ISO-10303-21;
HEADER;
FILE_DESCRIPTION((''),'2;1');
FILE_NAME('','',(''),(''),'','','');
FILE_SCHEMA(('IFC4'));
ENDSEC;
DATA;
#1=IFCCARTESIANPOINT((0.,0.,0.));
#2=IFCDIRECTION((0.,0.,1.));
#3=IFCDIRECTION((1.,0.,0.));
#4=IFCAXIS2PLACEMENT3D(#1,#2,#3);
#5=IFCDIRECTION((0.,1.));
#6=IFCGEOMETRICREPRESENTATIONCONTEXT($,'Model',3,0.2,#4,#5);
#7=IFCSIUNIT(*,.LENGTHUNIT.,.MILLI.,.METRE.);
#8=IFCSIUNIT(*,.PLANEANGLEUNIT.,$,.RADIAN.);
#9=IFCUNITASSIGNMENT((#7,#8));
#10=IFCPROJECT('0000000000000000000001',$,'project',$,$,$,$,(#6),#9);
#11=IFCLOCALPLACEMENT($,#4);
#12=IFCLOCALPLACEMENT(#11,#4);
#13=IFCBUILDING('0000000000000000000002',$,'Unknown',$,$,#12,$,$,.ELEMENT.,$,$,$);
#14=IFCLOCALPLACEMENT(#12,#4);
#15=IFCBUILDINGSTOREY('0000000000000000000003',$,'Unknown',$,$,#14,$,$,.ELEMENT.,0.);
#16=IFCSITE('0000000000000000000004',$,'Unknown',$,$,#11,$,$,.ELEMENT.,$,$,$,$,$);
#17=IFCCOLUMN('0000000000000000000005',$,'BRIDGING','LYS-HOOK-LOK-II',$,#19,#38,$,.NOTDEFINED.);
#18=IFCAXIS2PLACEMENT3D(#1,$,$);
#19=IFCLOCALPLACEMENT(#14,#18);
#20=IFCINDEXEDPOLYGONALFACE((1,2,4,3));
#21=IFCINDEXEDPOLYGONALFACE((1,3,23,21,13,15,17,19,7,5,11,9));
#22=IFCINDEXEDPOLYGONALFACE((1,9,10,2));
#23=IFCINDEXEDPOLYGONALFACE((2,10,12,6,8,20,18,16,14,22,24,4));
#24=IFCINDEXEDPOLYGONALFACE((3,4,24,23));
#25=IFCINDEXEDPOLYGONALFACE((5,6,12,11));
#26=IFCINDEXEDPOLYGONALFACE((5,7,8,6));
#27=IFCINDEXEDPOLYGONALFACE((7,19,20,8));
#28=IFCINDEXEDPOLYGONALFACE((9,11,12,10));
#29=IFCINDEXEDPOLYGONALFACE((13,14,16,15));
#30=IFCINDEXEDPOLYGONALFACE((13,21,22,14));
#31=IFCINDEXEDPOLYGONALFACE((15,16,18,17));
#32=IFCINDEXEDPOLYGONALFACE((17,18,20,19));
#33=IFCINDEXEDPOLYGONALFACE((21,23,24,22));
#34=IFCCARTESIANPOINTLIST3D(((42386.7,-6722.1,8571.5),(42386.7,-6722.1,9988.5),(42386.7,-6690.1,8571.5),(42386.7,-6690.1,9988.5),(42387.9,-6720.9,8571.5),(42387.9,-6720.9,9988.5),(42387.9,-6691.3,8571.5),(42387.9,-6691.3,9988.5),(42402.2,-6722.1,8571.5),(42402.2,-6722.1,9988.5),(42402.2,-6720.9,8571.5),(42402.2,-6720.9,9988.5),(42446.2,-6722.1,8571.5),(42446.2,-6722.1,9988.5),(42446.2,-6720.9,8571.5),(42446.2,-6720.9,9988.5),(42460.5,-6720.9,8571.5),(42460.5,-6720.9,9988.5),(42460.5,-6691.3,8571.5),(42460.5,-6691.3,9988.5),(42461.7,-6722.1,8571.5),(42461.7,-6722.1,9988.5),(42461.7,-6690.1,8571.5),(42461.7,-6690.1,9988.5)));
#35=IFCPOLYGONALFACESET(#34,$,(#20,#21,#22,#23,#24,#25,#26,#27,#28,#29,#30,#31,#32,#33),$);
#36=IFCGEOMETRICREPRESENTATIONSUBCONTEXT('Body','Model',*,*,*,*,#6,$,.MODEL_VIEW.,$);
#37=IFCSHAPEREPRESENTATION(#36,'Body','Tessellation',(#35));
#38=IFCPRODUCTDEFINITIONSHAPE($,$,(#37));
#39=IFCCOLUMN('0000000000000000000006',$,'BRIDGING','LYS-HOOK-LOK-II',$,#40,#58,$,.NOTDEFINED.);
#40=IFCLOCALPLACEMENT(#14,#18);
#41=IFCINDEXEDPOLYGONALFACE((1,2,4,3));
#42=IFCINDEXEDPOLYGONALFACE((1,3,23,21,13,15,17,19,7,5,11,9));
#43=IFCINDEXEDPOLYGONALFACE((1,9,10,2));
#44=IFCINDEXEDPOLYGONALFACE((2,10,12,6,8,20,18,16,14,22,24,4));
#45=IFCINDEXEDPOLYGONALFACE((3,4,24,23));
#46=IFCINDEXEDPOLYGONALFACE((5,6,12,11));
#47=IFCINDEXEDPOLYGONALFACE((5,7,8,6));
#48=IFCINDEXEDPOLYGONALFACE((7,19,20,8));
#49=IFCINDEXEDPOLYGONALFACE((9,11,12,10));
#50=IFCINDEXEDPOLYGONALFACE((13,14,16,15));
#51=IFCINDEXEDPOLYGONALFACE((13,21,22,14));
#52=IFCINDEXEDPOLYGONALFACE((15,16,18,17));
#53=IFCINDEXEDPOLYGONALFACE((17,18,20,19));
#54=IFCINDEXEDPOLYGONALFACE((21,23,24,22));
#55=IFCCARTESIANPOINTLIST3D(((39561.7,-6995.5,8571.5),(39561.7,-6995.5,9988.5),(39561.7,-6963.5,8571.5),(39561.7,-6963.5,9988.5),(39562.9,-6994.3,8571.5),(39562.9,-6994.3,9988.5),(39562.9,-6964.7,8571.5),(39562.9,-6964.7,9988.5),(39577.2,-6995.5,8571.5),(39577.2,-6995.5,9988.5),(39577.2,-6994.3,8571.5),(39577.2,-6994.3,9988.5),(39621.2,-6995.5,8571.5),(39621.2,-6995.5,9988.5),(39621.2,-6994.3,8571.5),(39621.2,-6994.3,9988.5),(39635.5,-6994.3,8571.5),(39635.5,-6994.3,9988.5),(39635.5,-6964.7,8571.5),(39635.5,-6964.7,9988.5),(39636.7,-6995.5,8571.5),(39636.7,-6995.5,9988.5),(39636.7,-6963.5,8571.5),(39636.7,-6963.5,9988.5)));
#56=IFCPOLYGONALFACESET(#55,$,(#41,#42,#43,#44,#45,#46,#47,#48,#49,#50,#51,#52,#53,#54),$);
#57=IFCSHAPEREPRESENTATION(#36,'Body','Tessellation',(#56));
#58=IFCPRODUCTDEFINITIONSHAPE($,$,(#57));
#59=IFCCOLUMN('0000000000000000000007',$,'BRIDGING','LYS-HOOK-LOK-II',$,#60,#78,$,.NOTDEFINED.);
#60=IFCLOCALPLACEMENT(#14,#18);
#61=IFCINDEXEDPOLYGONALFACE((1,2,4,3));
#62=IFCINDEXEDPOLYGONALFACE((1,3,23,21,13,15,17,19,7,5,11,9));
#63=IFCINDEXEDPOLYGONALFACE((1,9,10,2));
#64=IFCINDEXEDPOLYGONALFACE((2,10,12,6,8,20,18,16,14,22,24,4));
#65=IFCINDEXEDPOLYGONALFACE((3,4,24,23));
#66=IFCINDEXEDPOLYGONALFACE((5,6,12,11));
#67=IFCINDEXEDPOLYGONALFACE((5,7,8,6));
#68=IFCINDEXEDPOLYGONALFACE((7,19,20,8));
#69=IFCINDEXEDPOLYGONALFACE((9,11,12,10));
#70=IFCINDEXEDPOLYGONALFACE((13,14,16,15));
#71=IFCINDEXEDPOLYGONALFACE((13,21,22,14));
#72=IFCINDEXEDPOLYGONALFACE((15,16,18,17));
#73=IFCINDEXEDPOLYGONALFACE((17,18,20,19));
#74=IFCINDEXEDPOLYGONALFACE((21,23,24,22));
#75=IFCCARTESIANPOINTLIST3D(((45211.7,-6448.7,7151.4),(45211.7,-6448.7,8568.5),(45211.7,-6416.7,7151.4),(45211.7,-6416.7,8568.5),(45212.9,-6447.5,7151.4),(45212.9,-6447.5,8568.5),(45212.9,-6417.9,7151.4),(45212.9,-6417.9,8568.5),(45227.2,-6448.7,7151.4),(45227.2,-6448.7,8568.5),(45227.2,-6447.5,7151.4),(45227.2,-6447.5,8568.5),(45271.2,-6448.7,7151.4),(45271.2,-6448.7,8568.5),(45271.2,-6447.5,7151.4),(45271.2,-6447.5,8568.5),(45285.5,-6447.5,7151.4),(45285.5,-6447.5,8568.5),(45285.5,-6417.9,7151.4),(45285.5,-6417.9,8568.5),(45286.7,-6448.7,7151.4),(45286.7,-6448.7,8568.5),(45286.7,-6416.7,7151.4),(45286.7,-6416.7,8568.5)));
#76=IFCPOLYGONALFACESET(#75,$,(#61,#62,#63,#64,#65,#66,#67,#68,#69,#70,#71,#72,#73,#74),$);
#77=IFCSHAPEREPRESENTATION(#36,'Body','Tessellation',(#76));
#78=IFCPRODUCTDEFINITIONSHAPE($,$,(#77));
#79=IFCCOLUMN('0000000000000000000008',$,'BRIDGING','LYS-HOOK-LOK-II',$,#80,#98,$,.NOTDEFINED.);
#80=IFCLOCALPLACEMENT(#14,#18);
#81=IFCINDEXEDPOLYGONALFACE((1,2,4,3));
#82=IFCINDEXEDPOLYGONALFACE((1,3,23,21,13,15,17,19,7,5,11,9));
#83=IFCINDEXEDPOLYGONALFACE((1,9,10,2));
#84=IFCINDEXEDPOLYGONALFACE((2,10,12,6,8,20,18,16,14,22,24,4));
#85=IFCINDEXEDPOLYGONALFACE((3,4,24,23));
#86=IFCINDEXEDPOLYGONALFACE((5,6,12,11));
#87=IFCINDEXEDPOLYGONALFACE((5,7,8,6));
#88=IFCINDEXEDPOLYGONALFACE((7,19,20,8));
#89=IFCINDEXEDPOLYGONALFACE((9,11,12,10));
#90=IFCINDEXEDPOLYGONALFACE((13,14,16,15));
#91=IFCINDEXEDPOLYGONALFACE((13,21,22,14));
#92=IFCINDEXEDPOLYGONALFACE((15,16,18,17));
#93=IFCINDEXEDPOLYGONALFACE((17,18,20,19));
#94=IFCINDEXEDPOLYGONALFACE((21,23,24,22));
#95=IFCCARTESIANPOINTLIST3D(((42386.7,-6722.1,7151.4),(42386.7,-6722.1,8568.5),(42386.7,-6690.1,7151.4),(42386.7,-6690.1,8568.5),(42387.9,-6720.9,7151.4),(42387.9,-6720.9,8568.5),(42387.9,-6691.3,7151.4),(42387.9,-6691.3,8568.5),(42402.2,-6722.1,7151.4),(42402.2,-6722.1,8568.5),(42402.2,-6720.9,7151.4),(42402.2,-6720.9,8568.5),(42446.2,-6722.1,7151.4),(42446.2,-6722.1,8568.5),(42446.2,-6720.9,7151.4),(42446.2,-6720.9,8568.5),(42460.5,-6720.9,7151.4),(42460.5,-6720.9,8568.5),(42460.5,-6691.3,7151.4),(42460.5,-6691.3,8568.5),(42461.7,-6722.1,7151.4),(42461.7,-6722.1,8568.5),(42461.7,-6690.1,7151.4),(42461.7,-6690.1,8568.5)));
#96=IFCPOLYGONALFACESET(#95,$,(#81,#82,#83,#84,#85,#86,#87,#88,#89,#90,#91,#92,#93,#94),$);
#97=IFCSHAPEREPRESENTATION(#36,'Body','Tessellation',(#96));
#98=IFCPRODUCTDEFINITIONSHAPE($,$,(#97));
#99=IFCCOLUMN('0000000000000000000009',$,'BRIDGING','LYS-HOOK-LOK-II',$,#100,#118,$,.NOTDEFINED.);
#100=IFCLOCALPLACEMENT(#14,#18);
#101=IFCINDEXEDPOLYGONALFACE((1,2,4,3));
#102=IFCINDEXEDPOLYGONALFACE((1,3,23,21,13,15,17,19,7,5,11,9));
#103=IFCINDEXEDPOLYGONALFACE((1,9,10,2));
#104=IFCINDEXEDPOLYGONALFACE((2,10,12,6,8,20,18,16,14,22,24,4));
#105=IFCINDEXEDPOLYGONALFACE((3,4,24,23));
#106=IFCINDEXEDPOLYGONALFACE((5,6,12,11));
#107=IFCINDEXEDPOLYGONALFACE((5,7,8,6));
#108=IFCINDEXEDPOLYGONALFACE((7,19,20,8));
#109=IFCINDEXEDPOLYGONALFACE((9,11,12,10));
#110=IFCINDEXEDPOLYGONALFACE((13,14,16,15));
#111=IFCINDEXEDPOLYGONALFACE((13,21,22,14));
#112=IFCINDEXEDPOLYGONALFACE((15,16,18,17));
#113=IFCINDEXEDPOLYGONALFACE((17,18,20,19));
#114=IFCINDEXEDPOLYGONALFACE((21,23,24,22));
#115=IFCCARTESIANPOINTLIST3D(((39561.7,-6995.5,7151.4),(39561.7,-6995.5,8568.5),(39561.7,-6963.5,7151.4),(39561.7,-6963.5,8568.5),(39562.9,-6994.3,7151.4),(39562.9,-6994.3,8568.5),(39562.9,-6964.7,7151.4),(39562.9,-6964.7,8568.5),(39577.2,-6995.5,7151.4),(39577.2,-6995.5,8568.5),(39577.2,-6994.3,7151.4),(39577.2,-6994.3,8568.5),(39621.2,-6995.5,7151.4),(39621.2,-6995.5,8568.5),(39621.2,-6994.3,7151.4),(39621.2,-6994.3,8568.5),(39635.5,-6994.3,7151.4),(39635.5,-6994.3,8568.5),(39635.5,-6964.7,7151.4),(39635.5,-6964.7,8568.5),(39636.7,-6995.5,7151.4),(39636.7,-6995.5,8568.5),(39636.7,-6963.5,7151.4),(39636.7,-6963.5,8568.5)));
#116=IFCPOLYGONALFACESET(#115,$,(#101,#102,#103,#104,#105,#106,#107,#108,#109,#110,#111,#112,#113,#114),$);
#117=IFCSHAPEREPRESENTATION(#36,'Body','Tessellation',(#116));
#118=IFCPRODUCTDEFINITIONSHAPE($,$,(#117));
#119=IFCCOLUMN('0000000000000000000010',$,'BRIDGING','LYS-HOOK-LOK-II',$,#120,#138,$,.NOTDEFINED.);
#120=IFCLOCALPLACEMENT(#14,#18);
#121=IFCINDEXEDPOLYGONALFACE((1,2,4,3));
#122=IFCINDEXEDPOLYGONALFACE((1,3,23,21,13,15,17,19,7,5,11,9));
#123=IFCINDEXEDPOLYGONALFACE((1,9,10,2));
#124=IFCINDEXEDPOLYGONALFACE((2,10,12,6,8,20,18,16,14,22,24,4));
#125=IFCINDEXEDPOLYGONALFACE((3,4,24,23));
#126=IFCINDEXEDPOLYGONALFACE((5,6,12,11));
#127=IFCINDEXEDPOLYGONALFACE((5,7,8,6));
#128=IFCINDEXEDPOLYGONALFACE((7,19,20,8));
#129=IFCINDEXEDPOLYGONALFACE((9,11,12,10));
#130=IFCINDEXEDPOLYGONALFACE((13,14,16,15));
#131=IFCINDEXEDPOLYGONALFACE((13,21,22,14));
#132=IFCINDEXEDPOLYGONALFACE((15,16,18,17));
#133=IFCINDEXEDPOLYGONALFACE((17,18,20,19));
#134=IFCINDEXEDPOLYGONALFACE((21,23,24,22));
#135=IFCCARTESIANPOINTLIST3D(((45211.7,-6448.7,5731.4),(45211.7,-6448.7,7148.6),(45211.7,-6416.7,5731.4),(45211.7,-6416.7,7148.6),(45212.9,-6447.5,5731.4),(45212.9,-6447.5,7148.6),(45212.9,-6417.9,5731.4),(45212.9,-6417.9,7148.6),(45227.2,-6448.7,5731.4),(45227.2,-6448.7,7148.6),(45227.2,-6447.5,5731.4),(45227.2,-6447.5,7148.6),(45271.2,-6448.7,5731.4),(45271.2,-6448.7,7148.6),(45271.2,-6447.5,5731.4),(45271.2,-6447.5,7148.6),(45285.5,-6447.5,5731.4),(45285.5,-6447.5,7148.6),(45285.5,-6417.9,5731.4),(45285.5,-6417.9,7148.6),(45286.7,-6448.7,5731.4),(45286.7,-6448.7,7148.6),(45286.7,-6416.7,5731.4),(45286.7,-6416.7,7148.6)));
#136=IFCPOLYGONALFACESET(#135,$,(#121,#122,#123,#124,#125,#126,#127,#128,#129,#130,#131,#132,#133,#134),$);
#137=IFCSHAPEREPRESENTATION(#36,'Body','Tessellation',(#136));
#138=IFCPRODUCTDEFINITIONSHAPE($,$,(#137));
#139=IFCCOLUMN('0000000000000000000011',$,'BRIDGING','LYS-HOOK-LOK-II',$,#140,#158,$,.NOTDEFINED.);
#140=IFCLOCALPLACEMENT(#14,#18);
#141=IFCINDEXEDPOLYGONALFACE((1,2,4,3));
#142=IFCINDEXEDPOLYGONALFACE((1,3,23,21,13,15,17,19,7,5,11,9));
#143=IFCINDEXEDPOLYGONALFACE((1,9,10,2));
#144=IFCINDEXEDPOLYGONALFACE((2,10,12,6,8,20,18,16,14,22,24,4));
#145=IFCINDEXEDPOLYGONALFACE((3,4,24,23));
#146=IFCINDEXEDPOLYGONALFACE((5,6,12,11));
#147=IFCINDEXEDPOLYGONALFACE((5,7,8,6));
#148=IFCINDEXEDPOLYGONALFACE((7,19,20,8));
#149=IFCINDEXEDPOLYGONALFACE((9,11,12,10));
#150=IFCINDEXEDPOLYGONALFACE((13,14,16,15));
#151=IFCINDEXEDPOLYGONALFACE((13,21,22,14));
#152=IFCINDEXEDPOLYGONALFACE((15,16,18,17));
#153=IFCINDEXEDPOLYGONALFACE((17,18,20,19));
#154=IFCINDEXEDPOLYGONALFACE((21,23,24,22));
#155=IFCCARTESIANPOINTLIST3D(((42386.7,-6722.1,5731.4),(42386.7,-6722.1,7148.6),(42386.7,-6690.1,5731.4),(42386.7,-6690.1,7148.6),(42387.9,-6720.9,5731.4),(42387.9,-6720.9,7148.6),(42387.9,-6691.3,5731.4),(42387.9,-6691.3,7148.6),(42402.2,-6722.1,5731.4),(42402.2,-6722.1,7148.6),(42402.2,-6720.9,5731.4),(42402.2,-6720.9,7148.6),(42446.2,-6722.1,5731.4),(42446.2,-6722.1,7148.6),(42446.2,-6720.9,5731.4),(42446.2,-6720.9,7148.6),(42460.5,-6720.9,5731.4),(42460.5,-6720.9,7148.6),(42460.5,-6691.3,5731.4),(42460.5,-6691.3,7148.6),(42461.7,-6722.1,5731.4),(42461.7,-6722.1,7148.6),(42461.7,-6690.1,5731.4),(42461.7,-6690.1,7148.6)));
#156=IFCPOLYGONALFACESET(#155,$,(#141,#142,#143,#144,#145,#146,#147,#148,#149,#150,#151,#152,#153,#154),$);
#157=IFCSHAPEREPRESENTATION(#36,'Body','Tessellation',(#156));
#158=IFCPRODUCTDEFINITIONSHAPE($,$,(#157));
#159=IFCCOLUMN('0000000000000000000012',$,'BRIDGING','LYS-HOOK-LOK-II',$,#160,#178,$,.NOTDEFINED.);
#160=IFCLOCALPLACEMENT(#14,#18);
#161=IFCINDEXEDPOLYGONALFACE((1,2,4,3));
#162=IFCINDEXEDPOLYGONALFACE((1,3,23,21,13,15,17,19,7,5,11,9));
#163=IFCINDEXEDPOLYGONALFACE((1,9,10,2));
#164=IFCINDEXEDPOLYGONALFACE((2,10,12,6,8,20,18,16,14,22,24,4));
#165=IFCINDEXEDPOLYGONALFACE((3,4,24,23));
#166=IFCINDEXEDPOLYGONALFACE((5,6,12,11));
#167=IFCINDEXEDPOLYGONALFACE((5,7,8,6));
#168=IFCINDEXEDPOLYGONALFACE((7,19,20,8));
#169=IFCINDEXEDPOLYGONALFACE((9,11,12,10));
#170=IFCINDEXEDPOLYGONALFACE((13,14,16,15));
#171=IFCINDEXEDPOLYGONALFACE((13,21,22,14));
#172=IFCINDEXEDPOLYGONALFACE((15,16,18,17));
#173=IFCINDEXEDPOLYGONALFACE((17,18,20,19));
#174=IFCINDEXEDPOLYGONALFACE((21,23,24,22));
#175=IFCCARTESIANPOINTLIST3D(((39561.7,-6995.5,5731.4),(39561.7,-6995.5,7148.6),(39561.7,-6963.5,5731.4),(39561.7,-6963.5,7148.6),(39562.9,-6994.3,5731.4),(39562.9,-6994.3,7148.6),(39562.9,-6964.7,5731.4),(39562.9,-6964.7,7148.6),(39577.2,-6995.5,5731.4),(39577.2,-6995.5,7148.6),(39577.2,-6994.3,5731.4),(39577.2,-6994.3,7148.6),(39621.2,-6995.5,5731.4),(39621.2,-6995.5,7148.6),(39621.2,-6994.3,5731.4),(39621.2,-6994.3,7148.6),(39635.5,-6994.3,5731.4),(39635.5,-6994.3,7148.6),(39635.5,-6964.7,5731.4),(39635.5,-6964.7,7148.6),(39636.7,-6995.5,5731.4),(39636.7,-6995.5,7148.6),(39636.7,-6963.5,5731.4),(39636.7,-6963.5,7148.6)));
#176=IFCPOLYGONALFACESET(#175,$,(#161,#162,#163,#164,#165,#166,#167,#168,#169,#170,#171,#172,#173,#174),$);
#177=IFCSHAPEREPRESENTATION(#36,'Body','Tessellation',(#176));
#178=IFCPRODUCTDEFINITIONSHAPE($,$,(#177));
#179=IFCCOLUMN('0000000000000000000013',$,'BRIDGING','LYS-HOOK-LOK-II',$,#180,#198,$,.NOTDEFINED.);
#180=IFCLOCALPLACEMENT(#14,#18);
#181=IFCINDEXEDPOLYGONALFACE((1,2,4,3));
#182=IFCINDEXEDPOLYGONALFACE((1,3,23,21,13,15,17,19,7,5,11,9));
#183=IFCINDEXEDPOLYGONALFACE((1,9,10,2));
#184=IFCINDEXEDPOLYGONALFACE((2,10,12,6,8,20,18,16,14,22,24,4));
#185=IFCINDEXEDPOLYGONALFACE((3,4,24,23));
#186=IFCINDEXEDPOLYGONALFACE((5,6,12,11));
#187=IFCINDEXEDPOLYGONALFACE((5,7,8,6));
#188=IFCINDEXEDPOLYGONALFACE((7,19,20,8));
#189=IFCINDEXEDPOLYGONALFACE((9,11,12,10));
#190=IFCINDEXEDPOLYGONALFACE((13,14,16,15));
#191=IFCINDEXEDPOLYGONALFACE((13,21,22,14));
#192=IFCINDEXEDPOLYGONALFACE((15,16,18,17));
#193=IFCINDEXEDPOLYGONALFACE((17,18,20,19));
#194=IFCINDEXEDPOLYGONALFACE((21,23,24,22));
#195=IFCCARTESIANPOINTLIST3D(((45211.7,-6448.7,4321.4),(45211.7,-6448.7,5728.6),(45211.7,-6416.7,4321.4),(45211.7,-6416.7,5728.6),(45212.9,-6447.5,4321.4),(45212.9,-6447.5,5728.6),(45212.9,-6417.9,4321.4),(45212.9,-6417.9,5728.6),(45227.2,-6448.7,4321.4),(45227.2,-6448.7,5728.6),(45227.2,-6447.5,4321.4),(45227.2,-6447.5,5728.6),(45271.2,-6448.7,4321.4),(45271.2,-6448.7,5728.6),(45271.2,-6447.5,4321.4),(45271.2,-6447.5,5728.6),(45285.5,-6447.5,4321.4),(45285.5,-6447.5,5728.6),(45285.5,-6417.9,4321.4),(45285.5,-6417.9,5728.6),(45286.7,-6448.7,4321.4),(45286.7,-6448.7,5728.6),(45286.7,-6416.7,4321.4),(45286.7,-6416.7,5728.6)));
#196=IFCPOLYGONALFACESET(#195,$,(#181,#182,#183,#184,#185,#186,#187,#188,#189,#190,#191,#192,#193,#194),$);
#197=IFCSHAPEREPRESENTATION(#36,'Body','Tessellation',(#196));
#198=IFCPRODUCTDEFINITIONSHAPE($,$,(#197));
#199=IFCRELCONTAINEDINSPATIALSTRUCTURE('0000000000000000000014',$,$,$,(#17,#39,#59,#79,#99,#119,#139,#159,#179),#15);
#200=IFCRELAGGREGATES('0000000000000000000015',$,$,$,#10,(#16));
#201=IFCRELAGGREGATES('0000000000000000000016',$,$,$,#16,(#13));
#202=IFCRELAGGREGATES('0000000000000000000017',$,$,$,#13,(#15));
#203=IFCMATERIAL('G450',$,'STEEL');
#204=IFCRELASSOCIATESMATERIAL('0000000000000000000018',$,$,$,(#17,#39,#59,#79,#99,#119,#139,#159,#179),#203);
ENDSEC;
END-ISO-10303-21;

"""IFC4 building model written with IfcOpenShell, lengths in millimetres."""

from ifc_helpers import new_model, si_unit, direction, frame, origin_with_axes, place, context, subcontext, project, spatial, line, indexed_curve, outline, extrude, material, element, save


model = new_model("IFC4")

# Units and contexts
model_context = context("Model", 3, precision=0.2, world=origin_with_axes(), true_north=direction((0.0, 1.0)))
body_context = subcontext(model_context, "Body", "Model", "MODEL_VIEW")
ifc_project = project(units=[si_unit("LENGTHUNIT", "METRE", prefix="MILLI"), si_unit("PLANEANGLEUNIT", "RADIAN")], contexts=[model_context])

# Site, building, storey
site_placement = place(None, origin_with_axes())
site = spatial("IfcSite", under=ifc_project, at=site_placement, Name="Unknown", CompositionType="ELEMENT")
building_placement = place(site_placement, origin_with_axes())
building = spatial("IfcBuilding", under=site, at=building_placement, Name="Unknown", CompositionType="ELEMENT")
storey_placement = place(building_placement, origin_with_axes())
storey = spatial("IfcBuildingStorey", under=building, at=storey_placement, Name="Unknown", CompositionType="ELEMENT", Elevation=0.0)

# Columns
ifc_material_1 = material(Name="G450", Category="STEEL")
for number, where, z_axis, x_axis, name in (
    (1, (42424.2, -6706.1, 8571.5), (0.0, -1.0, 0.0), (0.0, 0.0, 1.0), "BRIDGING"),
    (2, (39599.2, -6979.5, 8571.5), (0.0, -1.0, 0.0), (0.0, 0.0, 1.0), "BRIDGING"),
):
    element("IfcColumn", number, at=place(storey_placement, frame(where, z_axis=z_axis, x_axis=x_axis)), inside=storey, material=ifc_material_1, Name=name, Description="LYS-HOOK-LOK-II", PredefinedType="NOTDEFINED", context=body_context, shape_type="SolidModel", body=[
        extrude(outline(indexed_curve([(16.0, -37.5), (16.0, -22.0), (14.8, -22.0), (14.8, -36.3), (-14.8, -36.3), (-14.8, 36.3), (14.8, 36.3), (14.8, 22.0), (16.0, 22.0), (16.0, 37.5), (-16.0, 37.5), (-16.0, -37.5)], segments=[line(1, 2, 3, 4, 5, 6, 7, 8, 9, 10, 11, 12, 1)])), frame((0.0, 0.0, 0.0), z_axis=(-1.0, 0.0, 0.0), x_axis=(0.0, 0.0, 1.0)), (0.0, 0.0, -1.0), 1417.0),
    ])
for number, where, z_axis, x_axis, name in (
    (3, (45249.2, -6432.7, 7151.4), (0.0, -1.0, 0.0), (0.0, 0.0, 1.0), "BRIDGING"),
    (4, (42424.2, -6706.1, 7151.4), (0.0, -1.0, 0.0), (0.0, 0.0, 1.0), "BRIDGING"),
    (5, (39599.2, -6979.5, 7151.4), (0.0, -1.0, 0.0), (0.0, 0.0, 1.0), "BRIDGING"),
):
    element("IfcColumn", number, at=place(storey_placement, frame(where, z_axis=z_axis, x_axis=x_axis)), inside=storey, material=ifc_material_1, Name=name, Description="LYS-HOOK-LOK-II", PredefinedType="NOTDEFINED", context=body_context, shape_type="SolidModel", body=[
        extrude(outline(indexed_curve([(16.0, -37.5), (16.0, -22.0), (14.8, -22.0), (14.8, -36.3), (-14.8, -36.3), (-14.8, 36.3), (14.8, 36.3), (14.8, 22.0), (16.0, 22.0), (16.0, 37.5), (-16.0, 37.5), (-16.0, -37.5)], segments=[line(1, 2, 3, 4, 5, 6, 7, 8, 9, 10, 11, 12, 1)])), frame((0.0, 0.0, 0.0), z_axis=(-1.0, 0.0, 0.0), x_axis=(0.0, 0.0, 1.0)), (0.0, 0.0, -1.0), 1417.1),
    ])
for number, where, z_axis, x_axis, name in (
    (6, (45249.2, -6432.7, 5731.4), (0.0, -1.0, 0.0), (0.0, 0.0, 1.0), "BRIDGING"),
    (7, (42424.2, -6706.1, 5731.4), (0.0, -1.0, 0.0), (0.0, 0.0, 1.0), "BRIDGING"),
    (8, (39599.2, -6979.5, 5731.4), (0.0, -1.0, 0.0), (0.0, 0.0, 1.0), "BRIDGING"),
):
    element("IfcColumn", number, at=place(storey_placement, frame(where, z_axis=z_axis, x_axis=x_axis)), inside=storey, material=ifc_material_1, Name=name, Description="LYS-HOOK-LOK-II", PredefinedType="NOTDEFINED", context=body_context, shape_type="SolidModel", body=[
        extrude(outline(indexed_curve([(16.0, -37.5), (16.0, -22.0), (14.8, -22.0), (14.8, -36.3), (-14.8, -36.3), (-14.8, 36.3), (14.8, 36.3), (14.8, 22.0), (16.0, 22.0), (16.0, 37.5), (-16.0, 37.5), (-16.0, -37.5)], segments=[line(1, 2, 3, 4, 5, 6, 7, 8, 9, 10, 11, 12, 1)])), frame((0.0, 0.0, 0.0), z_axis=(-1.0, 0.0, 0.0), x_axis=(0.0, 0.0, 1.0)), (0.0, 0.0, -1.0), 1417.2),
    ])
for number, where, z_axis, x_axis, name in (
    (9, (45249.2, -6432.7, 4321.4), (0.0, -1.0, 0.0), (0.0, 0.0, 1.0), "BRIDGING"),
):
    element("IfcColumn", number, at=place(storey_placement, frame(where, z_axis=z_axis, x_axis=x_axis)), inside=storey, material=ifc_material_1, Name=name, Description="LYS-HOOK-LOK-II", PredefinedType="NOTDEFINED", context=body_context, shape_type="SolidModel", body=[
        extrude(outline(indexed_curve([(16.0, -37.5), (16.0, -22.0), (14.8, -22.0), (14.8, -36.3), (-14.8, -36.3), (-14.8, 36.3), (14.8, 36.3), (14.8, 22.0), (16.0, 22.0), (16.0, 37.5), (-16.0, 37.5), (-16.0, -37.5)], segments=[line(1, 2, 3, 4, 5, 6, 7, 8, 9, 10, 11, 12, 1)])), frame((0.0, 0.0, 0.0), z_axis=(-1.0, 0.0, 0.0), x_axis=(0.0, 0.0, 1.0)), (0.0, 0.0, -1.0), 1407.2),
    ])

save(model, "model.ifc")
